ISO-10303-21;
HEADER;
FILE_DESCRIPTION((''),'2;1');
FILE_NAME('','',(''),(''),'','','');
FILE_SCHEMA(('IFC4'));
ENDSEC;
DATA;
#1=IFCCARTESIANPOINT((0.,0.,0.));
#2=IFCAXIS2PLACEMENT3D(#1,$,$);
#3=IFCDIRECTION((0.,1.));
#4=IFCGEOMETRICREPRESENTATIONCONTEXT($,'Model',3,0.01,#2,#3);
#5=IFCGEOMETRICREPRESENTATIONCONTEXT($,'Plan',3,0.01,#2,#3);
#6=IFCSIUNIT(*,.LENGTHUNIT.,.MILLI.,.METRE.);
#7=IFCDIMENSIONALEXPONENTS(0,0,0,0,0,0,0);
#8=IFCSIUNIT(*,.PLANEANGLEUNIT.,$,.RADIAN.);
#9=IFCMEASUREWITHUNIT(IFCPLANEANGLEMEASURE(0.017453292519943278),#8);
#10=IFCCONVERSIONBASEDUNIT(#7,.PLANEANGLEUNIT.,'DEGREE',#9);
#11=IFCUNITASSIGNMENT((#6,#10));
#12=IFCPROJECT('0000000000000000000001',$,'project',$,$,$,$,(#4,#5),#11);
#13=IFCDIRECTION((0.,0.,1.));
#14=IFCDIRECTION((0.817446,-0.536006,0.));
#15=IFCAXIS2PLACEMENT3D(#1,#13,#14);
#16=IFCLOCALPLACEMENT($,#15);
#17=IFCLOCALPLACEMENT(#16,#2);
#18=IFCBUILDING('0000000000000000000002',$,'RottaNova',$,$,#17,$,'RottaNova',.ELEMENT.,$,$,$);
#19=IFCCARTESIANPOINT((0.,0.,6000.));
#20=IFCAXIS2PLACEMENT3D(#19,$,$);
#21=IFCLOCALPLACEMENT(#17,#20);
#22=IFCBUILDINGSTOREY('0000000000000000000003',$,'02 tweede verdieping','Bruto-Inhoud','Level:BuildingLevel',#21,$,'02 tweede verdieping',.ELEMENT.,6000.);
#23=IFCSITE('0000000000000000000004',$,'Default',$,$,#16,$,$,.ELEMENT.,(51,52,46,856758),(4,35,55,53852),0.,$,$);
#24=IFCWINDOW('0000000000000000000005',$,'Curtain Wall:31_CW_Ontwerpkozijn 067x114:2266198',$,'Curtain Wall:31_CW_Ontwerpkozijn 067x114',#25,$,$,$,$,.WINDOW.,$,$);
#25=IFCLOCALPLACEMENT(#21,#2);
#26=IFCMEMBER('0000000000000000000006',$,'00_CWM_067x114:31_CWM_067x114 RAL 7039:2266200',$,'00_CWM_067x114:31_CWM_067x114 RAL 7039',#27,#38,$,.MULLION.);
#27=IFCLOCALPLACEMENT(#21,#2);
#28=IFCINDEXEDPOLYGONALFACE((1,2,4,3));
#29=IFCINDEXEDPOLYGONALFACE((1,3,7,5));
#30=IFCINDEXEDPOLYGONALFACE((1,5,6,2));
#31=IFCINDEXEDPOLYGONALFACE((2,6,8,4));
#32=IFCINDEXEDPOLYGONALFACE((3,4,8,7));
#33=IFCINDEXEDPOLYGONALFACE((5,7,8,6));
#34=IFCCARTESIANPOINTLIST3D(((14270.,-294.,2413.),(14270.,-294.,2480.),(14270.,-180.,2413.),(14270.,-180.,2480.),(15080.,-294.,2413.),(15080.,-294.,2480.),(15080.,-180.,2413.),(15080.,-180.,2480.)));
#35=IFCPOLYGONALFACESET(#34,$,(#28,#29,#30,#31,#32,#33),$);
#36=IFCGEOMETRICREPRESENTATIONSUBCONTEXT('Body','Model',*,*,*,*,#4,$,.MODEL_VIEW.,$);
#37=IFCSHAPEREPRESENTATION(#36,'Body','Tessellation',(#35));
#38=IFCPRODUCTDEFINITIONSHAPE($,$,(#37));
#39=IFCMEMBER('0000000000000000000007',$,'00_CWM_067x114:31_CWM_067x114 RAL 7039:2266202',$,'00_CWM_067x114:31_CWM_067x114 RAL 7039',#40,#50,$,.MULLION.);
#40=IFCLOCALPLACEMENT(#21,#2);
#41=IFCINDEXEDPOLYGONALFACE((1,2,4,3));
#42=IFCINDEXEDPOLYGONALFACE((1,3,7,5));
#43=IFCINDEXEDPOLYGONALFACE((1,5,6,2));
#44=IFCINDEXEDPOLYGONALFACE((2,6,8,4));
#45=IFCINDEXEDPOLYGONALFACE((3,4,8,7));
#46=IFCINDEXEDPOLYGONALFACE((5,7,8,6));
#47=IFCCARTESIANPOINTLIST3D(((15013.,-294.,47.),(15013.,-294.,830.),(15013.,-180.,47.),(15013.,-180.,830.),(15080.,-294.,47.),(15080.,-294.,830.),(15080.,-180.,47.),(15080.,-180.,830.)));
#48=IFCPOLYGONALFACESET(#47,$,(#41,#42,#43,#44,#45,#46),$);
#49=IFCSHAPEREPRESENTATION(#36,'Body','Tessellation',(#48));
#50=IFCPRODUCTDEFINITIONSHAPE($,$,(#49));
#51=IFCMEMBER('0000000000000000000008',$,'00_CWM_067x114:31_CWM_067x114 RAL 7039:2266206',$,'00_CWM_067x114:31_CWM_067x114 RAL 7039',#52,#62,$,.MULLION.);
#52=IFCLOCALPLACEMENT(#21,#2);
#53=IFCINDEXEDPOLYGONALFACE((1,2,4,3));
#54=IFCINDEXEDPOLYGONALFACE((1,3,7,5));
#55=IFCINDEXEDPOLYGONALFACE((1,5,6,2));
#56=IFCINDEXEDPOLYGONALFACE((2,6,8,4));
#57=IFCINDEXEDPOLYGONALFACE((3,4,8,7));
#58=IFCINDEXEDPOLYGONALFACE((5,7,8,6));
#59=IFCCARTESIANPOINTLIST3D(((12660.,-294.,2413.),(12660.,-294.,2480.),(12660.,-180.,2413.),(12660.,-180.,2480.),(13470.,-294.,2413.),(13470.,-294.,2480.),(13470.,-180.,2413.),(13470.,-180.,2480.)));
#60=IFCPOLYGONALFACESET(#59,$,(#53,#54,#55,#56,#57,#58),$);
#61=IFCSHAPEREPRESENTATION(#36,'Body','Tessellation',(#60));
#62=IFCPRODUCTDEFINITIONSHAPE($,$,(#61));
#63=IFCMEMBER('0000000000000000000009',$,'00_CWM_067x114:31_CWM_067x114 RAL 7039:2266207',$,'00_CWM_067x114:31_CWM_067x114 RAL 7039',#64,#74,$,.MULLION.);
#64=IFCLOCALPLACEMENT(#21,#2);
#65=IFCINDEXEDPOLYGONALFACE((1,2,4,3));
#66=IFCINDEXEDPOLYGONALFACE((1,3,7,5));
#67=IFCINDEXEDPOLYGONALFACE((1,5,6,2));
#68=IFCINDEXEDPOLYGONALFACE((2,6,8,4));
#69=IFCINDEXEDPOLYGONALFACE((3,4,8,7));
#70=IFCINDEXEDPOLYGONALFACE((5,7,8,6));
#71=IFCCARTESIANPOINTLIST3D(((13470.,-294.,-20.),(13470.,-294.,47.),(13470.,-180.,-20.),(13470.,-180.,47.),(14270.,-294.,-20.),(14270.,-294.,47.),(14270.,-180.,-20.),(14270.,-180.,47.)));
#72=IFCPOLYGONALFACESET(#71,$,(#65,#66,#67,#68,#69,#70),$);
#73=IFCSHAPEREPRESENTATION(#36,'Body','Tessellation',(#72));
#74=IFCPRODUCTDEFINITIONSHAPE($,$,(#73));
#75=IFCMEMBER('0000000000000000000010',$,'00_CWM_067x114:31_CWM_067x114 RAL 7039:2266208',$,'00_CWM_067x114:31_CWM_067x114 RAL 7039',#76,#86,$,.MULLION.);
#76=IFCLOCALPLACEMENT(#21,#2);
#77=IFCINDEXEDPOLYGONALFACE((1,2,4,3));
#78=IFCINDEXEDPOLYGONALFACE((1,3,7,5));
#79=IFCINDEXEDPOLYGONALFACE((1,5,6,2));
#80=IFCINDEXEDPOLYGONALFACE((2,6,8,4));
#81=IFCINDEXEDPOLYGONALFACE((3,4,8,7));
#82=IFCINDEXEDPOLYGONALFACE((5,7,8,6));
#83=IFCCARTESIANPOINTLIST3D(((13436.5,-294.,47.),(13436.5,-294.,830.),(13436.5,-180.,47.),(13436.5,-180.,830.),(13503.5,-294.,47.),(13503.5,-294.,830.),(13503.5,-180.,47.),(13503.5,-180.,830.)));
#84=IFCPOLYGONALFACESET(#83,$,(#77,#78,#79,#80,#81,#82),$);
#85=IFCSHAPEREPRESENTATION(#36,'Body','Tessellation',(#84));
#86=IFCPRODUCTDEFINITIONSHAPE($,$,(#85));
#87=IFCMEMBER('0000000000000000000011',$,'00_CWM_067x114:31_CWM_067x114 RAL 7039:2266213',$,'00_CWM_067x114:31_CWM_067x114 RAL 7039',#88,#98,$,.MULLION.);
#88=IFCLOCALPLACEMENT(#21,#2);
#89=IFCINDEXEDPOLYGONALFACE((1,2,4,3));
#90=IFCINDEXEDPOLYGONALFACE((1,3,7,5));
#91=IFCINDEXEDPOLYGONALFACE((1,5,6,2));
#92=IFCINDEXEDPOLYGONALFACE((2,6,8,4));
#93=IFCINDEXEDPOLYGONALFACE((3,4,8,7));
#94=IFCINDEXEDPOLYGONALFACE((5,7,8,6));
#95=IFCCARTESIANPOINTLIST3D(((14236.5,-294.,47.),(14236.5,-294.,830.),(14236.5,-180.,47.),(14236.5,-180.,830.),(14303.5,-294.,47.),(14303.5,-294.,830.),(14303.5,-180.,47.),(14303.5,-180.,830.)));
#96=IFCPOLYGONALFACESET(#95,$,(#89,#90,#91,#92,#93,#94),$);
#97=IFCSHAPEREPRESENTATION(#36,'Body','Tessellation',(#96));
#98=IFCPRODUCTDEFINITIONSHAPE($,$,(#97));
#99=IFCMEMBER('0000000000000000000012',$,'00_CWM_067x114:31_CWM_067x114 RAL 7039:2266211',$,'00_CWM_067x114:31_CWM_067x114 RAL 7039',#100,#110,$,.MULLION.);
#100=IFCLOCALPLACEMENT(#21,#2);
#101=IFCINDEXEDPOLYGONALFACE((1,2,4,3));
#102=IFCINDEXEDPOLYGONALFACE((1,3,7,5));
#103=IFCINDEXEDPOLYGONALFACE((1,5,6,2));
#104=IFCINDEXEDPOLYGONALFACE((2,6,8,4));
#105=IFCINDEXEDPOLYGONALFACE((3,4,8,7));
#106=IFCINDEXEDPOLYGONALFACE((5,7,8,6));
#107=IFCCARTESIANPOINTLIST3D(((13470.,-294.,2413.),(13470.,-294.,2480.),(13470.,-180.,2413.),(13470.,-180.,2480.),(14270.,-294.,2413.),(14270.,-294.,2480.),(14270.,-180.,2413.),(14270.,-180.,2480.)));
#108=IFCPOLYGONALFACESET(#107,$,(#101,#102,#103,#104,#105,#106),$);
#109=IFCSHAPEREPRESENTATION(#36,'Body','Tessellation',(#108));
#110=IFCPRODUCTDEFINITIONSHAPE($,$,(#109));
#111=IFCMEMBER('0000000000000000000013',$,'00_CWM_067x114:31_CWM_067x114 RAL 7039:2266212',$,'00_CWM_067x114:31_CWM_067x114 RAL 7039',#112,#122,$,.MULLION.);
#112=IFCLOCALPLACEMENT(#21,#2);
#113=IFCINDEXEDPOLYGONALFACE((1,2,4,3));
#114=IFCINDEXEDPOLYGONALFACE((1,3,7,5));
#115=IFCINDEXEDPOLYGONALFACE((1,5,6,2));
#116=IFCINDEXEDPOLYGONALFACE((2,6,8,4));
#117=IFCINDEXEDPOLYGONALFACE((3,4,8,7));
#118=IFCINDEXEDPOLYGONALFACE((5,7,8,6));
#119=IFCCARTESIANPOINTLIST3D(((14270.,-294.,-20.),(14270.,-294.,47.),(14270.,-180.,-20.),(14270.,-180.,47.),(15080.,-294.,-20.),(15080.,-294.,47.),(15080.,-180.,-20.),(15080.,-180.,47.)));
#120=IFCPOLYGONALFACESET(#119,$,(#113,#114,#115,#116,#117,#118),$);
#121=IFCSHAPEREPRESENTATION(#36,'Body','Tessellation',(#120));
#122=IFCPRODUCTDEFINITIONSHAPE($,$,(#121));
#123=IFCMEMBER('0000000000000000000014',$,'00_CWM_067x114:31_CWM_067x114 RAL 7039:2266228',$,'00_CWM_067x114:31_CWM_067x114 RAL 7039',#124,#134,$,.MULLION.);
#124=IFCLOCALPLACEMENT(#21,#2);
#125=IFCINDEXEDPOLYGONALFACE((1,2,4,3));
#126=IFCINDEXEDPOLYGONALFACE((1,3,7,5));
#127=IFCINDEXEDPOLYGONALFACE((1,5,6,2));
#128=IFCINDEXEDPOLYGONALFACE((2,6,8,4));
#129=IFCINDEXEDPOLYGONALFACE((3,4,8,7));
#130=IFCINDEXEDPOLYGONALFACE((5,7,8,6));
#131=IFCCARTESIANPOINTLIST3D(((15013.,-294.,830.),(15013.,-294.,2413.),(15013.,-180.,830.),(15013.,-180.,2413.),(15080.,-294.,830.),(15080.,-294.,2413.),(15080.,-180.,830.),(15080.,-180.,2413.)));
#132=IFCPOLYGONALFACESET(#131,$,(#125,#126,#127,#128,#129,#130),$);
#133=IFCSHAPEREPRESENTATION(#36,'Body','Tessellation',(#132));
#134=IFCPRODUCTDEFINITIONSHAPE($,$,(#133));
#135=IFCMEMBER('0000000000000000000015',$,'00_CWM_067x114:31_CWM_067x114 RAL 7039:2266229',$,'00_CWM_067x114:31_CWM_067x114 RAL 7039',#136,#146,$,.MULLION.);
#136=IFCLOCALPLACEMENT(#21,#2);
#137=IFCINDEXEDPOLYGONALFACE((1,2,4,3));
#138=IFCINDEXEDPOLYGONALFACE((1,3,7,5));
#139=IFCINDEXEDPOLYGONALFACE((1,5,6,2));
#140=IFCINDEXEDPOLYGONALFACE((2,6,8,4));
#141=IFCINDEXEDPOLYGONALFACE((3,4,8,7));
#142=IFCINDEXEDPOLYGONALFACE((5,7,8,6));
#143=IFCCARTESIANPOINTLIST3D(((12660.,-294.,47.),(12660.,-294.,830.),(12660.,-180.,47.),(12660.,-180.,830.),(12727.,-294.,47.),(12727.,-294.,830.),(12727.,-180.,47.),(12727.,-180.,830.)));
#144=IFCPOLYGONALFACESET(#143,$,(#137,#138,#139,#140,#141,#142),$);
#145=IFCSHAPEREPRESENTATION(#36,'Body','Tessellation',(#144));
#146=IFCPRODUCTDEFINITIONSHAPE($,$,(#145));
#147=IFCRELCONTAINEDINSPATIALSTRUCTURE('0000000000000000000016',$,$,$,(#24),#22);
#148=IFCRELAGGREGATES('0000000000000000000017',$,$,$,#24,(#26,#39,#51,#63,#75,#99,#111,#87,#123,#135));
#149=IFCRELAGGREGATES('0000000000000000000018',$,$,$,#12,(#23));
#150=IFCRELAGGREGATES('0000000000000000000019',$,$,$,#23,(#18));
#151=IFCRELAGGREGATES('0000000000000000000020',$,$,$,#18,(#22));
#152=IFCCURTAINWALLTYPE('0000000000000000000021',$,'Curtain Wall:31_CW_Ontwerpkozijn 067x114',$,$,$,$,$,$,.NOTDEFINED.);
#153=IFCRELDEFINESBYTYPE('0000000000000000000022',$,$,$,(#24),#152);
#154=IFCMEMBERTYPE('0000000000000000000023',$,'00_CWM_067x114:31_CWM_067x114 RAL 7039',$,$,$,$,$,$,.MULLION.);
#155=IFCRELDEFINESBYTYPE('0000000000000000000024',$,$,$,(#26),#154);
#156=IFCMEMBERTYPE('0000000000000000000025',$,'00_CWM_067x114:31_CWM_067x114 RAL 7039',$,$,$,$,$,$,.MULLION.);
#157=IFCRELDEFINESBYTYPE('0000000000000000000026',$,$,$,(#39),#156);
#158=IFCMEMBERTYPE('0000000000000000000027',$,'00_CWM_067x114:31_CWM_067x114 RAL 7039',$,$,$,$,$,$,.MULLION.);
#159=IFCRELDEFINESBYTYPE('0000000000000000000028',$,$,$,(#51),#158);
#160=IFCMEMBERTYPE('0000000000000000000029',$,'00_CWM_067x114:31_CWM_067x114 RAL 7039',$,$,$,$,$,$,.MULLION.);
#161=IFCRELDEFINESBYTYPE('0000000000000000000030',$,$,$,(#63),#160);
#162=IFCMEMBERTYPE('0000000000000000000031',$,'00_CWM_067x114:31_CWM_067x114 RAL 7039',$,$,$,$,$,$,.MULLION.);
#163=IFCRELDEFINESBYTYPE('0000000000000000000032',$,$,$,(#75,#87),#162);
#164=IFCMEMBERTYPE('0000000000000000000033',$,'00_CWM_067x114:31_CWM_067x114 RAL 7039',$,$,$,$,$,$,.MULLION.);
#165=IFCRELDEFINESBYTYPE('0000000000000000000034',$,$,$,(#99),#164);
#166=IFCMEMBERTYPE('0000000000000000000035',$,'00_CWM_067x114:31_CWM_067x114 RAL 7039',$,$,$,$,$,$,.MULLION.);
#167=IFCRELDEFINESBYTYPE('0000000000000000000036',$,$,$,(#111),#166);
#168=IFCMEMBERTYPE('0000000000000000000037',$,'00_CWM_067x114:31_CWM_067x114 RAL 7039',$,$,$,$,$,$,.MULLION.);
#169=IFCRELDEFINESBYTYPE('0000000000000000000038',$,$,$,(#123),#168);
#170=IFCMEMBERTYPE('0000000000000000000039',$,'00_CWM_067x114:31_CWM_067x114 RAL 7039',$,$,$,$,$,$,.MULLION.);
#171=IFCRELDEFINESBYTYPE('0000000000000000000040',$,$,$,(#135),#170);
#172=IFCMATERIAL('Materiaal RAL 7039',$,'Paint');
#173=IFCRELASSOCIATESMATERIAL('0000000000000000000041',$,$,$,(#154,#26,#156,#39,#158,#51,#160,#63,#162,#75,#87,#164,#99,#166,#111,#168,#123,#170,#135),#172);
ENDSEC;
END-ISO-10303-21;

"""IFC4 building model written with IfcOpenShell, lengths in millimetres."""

from ifc_helpers import new_model, entity, si_unit, converted_unit, direction, frame, origin, place, context, subcontext, project, spatial, indexed_curve, outline, extrude, source, transform, mapped, material, type_object, type_shapes, element, aggregate, save


model = new_model("IFC4")

# Units and contexts
model_context = context("Model", 3, precision=0.01, world=origin(), true_north=direction((0.0, 1.0)))
plan_context = context("Plan", 3, precision=0.01, world=origin(), true_north=direction((0.0, 1.0)))
body_context = subcontext(model_context, "Body", "Model", "MODEL_VIEW")
ifc_project = project(units=[si_unit("LENGTHUNIT", "METRE", prefix="MILLI"), converted_unit("PLANEANGLEUNIT", "DEGREE", entity("IfcPlaneAngleMeasure", 0.017453292519943278), si_unit("PLANEANGLEUNIT", "RADIAN"), dimensions=[0, 0, 0, 0, 0, 0, 0])], contexts=[model_context, plan_context])

# Site, building, storey
site_placement = place(None, frame((0.0, 0.0, 0.0), z_axis=(0.0, 0.0, 1.0), x_axis=(0.817446, -0.536006, 0.0)))
site = spatial("IfcSite", under=ifc_project, at=site_placement, Name="Default", CompositionType="ELEMENT", RefLatitude=(51, 52, 46, 856758), RefLongitude=(4, 35, 55, 53852), RefElevation=0.0)
building_placement = place(site_placement, origin())
building = spatial("IfcBuilding", under=site, at=building_placement, Name="RottaNova", LongName="RottaNova", CompositionType="ELEMENT")
storey_placement = place(building_placement, frame((0.0, 0.0, 6000.0)))
storey = spatial("IfcBuildingStorey", under=building, at=storey_placement, Name="02 tweede verdieping", Description="Bruto-Inhoud", ObjectType="Level:BuildingLevel", LongName="02 tweede verdieping", CompositionType="ELEMENT", Elevation=6000.0)

# Window, members
curtain_wall_type = type_object("IfcCurtainWallType", Name="Curtain Wall:31_CW_Ontwerpkozijn 067x114", PredefinedType="NOTDEFINED")
window_1_placement = place(storey_placement, frame((0.0, 0.0, -6000.0)))
window_1 = element("IfcWindow", 1, at=window_1_placement, inside=storey, type_object=curtain_wall_type, Name="Curtain Wall:31_CW_Ontwerpkozijn 067x114:2266198", ObjectType="Curtain Wall:31_CW_Ontwerpkozijn 067x114", PredefinedType="WINDOW")
ifc_material_1 = material(Name="Materiaal RAL 7039", Category="Paint")
member_type_1 = type_object("IfcMemberType", Name="00_CWM_067x114:31_CWM_067x114 RAL 7039", PredefinedType="MULLION", material=ifc_material_1)
shared_shape_1 = source(origin(), body_context, "Body", "SweptSolid", [
    extrude(outline(indexed_curve([(-33.5, -57.0), (33.5, -57.0), (33.5, 57.0), (-33.5, 57.0), (-33.5, -57.0)], self_intersect=False)), frame((-33.5, 57.0, -810.0), z_axis=(0.0, 0.0, 1.0), x_axis=(-1.0, 0.0, 0.0)), (0.0, 0.0, 1.0), 810.0),
])
type_shapes(member_type_1, [shared_shape_1])
member_1_placement = place(window_1_placement, frame((15080.0, -180.0, 8480.0), z_axis=(1.0, 0.0, 0.0), x_axis=(0.0, 0.0, 1.0)))
member_1 = element("IfcMember", 2, at=member_1_placement, type_object=member_type_1, material=ifc_material_1, Name="00_CWM_067x114:31_CWM_067x114 RAL 7039:2266200", ObjectType="00_CWM_067x114:31_CWM_067x114 RAL 7039", PredefinedType="MULLION", context=body_context, shape_type="MappedRepresentation", body=[
    mapped(shared_shape_1, transform((0.0, 0.0, 0.0), scale=1.0)),
])
member_type_2 = type_object("IfcMemberType", Name="00_CWM_067x114:31_CWM_067x114 RAL 7039", PredefinedType="MULLION", material=ifc_material_1)
shared_shape_2 = source(origin(), body_context, "Body", "SweptSolid", [
    extrude(outline(indexed_curve([(-33.5, -57.0), (33.5, -57.0), (33.5, 57.0), (-33.5, 57.0), (-33.5, -57.0)], self_intersect=False)), frame((-33.5, 57.0, -783.0), z_axis=(0.0, 0.0, 1.0), x_axis=(-1.0, 0.0, 0.0)), (0.0, 0.0, 1.0), 783.0),
])
type_shapes(member_type_2, [shared_shape_2])
member_2_placement = place(window_1_placement, frame((15080.0, -180.0, 6047.0), z_axis=(0.0, 0.0, -1.0), x_axis=(1.0, 0.0, 0.0)))
member_2 = element("IfcMember", 3, at=member_2_placement, type_object=member_type_2, material=ifc_material_1, Name="00_CWM_067x114:31_CWM_067x114 RAL 7039:2266202", ObjectType="00_CWM_067x114:31_CWM_067x114 RAL 7039", PredefinedType="MULLION", context=body_context, shape_type="MappedRepresentation", body=[
    mapped(shared_shape_2, transform((0.0, 0.0, 0.0), scale=1.0)),
])
member_type_3 = type_object("IfcMemberType", Name="00_CWM_067x114:31_CWM_067x114 RAL 7039", PredefinedType="MULLION", material=ifc_material_1)
shared_shape_3 = source(origin(), body_context, "Body", "SweptSolid", [
    extrude(outline(indexed_curve([(-33.5, -57.0), (33.5, -57.0), (33.5, 57.0), (-33.5, 57.0), (-33.5, -57.0)], self_intersect=False)), frame((-33.5, 57.0, -810.0), z_axis=(0.0, 0.0, 1.0), x_axis=(-1.0, 0.0, 0.0)), (0.0, 0.0, 1.0), 810.0),
])
type_shapes(member_type_3, [shared_shape_3])
member_3_placement = place(window_1_placement, frame((13470.0, -180.0, 8480.0), z_axis=(1.0, 0.0, 0.0), x_axis=(0.0, 0.0, 1.0)))
member_3 = element("IfcMember", 4, at=member_3_placement, type_object=member_type_3, material=ifc_material_1, Name="00_CWM_067x114:31_CWM_067x114 RAL 7039:2266206", ObjectType="00_CWM_067x114:31_CWM_067x114 RAL 7039", PredefinedType="MULLION", context=body_context, shape_type="MappedRepresentation", body=[
    mapped(shared_shape_3, transform((0.0, 0.0, 0.0), scale=1.0)),
])
member_type_4 = type_object("IfcMemberType", Name="00_CWM_067x114:31_CWM_067x114 RAL 7039", PredefinedType="MULLION", material=ifc_material_1)
shared_shape_4 = source(origin(), body_context, "Body", "SweptSolid", [
    extrude(outline(indexed_curve([(-33.5, -57.0), (33.5, -57.0), (33.5, 57.0), (-33.5, 57.0), (-33.5, -57.0)], self_intersect=False)), frame((-33.5, 57.0, -800.0), z_axis=(0.0, 0.0, 1.0), x_axis=(-1.0, 0.0, 0.0)), (0.0, 0.0, 1.0), 800.0),
])
type_shapes(member_type_4, [shared_shape_4])
member_4_placement = place(window_1_placement, frame((13470.0, -180.0, 5980.0), z_axis=(-1.0, 0.0, 0.0), x_axis=(0.0, 0.0, -1.0)))
member_4 = element("IfcMember", 5, at=member_4_placement, type_object=member_type_4, material=ifc_material_1, Name="00_CWM_067x114:31_CWM_067x114 RAL 7039:2266207", ObjectType="00_CWM_067x114:31_CWM_067x114 RAL 7039", PredefinedType="MULLION", context=body_context, shape_type="MappedRepresentation", body=[
    mapped(shared_shape_4, transform((0.0, 0.0, 0.0), scale=1.0)),
])
member_type_5 = type_object("IfcMemberType", Name="00_CWM_067x114:31_CWM_067x114 RAL 7039", PredefinedType="MULLION", material=ifc_material_1)
shared_shape_5 = source(origin(), body_context, "Body", "SweptSolid", [
    extrude(outline(indexed_curve([(-33.5, -57.0), (33.5, -57.0), (33.5, 57.0), (-33.5, 57.0), (-33.5, -57.0)], self_intersect=False)), frame((0.0, 57.0, -783.0), z_axis=(0.0, 0.0, 1.0), x_axis=(-1.0, 0.0, 0.0)), (0.0, 0.0, 1.0), 783.0),
])
type_shapes(member_type_5, [shared_shape_5])
member_5_placement = place(window_1_placement, frame((13470.0, -180.0, 6047.0), z_axis=(0.0, 0.0, -1.0), x_axis=(1.0, 0.0, 0.0)))
member_5 = element("IfcMember", 6, at=member_5_placement, type_object=member_type_5, material=ifc_material_1, Name="00_CWM_067x114:31_CWM_067x114 RAL 7039:2266208", ObjectType="00_CWM_067x114:31_CWM_067x114 RAL 7039", PredefinedType="MULLION", context=body_context, shape_type="MappedRepresentation", body=[
    mapped(shared_shape_5, transform((0.0, 0.0, 0.0), scale=1.0)),
])
member_6_placement = place(window_1_placement, frame((14270.0, -180.0, 6047.0), z_axis=(0.0, 0.0, -1.0), x_axis=(1.0, 0.0, 0.0)))
member_6 = element("IfcMember", 7, at=member_6_placement, type_object=member_type_5, material=ifc_material_1, Name="00_CWM_067x114:31_CWM_067x114 RAL 7039:2266213", ObjectType="00_CWM_067x114:31_CWM_067x114 RAL 7039", PredefinedType="MULLION", context=body_context, shape_type="MappedRepresentation", body=[
    mapped(shared_shape_5, transform((0.0, 0.0, 0.0), scale=1.0)),
])
member_type_6 = type_object("IfcMemberType", Name="00_CWM_067x114:31_CWM_067x114 RAL 7039", PredefinedType="MULLION", material=ifc_material_1)
shared_shape_6 = source(origin(), body_context, "Body", "SweptSolid", [
    extrude(outline(indexed_curve([(-33.5, -57.0), (33.5, -57.0), (33.5, 57.0), (-33.5, 57.0), (-33.5, -57.0)], self_intersect=False)), frame((-33.5, 57.0, -800.0), z_axis=(0.0, 0.0, 1.0), x_axis=(-1.0, 0.0, 0.0)), (0.0, 0.0, 1.0), 800.0),
])
type_shapes(member_type_6, [shared_shape_6])
member_7_placement = place(window_1_placement, frame((14270.0, -180.0, 8480.0), z_axis=(1.0, 0.0, 0.0), x_axis=(0.0, 0.0, 1.0)))
member_7 = element("IfcMember", 8, at=member_7_placement, type_object=member_type_6, material=ifc_material_1, Name="00_CWM_067x114:31_CWM_067x114 RAL 7039:2266211", ObjectType="00_CWM_067x114:31_CWM_067x114 RAL 7039", PredefinedType="MULLION", context=body_context, shape_type="MappedRepresentation", body=[
    mapped(shared_shape_6, transform((0.0, 0.0, 0.0), scale=1.0)),
])
member_type_7 = type_object("IfcMemberType", Name="00_CWM_067x114:31_CWM_067x114 RAL 7039", PredefinedType="MULLION", material=ifc_material_1)
shared_shape_7 = source(origin(), body_context, "Body", "SweptSolid", [
    extrude(outline(indexed_curve([(-33.5, -57.0), (33.5, -57.0), (33.5, 57.0), (-33.5, 57.0), (-33.5, -57.0)], self_intersect=False)), frame((-33.5, 57.0, -810.0), z_axis=(0.0, 0.0, 1.0), x_axis=(-1.0, 0.0, 0.0)), (0.0, 0.0, 1.0), 810.0),
])
type_shapes(member_type_7, [shared_shape_7])
member_8_placement = place(window_1_placement, frame((14270.0, -180.0, 5980.0), z_axis=(-1.0, 0.0, 0.0), x_axis=(0.0, 0.0, -1.0)))
member_8 = element("IfcMember", 9, at=member_8_placement, type_object=member_type_7, material=ifc_material_1, Name="00_CWM_067x114:31_CWM_067x114 RAL 7039:2266212", ObjectType="00_CWM_067x114:31_CWM_067x114 RAL 7039", PredefinedType="MULLION", context=body_context, shape_type="MappedRepresentation", body=[
    mapped(shared_shape_7, transform((0.0, 0.0, 0.0), scale=1.0)),
])
member_type_8 = type_object("IfcMemberType", Name="00_CWM_067x114:31_CWM_067x114 RAL 7039", PredefinedType="MULLION", material=ifc_material_1)
shared_shape_8 = source(origin(), body_context, "Body", "SweptSolid", [
    extrude(outline(indexed_curve([(-33.5, -57.0), (33.5, -57.0), (33.5, 57.0), (-33.5, 57.0), (-33.5, -57.0)], self_intersect=False)), frame((-33.5, 57.0, -1583.0), z_axis=(0.0, 0.0, 1.0), x_axis=(-1.0, 0.0, 0.0)), (0.0, 0.0, 1.0), 1583.0),
])
type_shapes(member_type_8, [shared_shape_8])
member_9_placement = place(window_1_placement, frame((15080.0, -180.0, 6830.0), z_axis=(0.0, 0.0, -1.0), x_axis=(1.0, 0.0, 0.0)))
member_9 = element("IfcMember", 10, at=member_9_placement, type_object=member_type_8, material=ifc_material_1, Name="00_CWM_067x114:31_CWM_067x114 RAL 7039:2266228", ObjectType="00_CWM_067x114:31_CWM_067x114 RAL 7039", PredefinedType="MULLION", context=body_context, shape_type="MappedRepresentation", body=[
    mapped(shared_shape_8, transform((0.0, 0.0, 0.0), scale=1.0)),
])
member_type_9 = type_object("IfcMemberType", Name="00_CWM_067x114:31_CWM_067x114 RAL 7039", PredefinedType="MULLION", material=ifc_material_1)
shared_shape_9 = source(origin(), body_context, "Body", "SweptSolid", [
    extrude(outline(indexed_curve([(-33.5, -57.0), (33.5, -57.0), (33.5, 57.0), (-33.5, 57.0), (-33.5, -57.0)], self_intersect=False)), frame((-33.5, 57.0, -783.0), z_axis=(0.0, 0.0, 1.0), x_axis=(-1.0, 0.0, 0.0)), (0.0, 0.0, 1.0), 783.0),
])
type_shapes(member_type_9, [shared_shape_9])
member_10_placement = place(window_1_placement, frame((12660.0, -180.0, 6830.0), z_axis=(0.0, 0.0, 1.0), x_axis=(-1.0, 0.0, 0.0)))
member_10 = element("IfcMember", 11, at=member_10_placement, type_object=member_type_9, material=ifc_material_1, Name="00_CWM_067x114:31_CWM_067x114 RAL 7039:2266229", ObjectType="00_CWM_067x114:31_CWM_067x114 RAL 7039", PredefinedType="MULLION", context=body_context, shape_type="MappedRepresentation", body=[
    mapped(shared_shape_9, transform((0.0, 0.0, 0.0), scale=1.0)),
])
aggregate(window_1, [member_1, member_2, member_3, member_4, member_5, member_7, member_8, member_6, member_9, member_10])

save(model, "model.ifc")
